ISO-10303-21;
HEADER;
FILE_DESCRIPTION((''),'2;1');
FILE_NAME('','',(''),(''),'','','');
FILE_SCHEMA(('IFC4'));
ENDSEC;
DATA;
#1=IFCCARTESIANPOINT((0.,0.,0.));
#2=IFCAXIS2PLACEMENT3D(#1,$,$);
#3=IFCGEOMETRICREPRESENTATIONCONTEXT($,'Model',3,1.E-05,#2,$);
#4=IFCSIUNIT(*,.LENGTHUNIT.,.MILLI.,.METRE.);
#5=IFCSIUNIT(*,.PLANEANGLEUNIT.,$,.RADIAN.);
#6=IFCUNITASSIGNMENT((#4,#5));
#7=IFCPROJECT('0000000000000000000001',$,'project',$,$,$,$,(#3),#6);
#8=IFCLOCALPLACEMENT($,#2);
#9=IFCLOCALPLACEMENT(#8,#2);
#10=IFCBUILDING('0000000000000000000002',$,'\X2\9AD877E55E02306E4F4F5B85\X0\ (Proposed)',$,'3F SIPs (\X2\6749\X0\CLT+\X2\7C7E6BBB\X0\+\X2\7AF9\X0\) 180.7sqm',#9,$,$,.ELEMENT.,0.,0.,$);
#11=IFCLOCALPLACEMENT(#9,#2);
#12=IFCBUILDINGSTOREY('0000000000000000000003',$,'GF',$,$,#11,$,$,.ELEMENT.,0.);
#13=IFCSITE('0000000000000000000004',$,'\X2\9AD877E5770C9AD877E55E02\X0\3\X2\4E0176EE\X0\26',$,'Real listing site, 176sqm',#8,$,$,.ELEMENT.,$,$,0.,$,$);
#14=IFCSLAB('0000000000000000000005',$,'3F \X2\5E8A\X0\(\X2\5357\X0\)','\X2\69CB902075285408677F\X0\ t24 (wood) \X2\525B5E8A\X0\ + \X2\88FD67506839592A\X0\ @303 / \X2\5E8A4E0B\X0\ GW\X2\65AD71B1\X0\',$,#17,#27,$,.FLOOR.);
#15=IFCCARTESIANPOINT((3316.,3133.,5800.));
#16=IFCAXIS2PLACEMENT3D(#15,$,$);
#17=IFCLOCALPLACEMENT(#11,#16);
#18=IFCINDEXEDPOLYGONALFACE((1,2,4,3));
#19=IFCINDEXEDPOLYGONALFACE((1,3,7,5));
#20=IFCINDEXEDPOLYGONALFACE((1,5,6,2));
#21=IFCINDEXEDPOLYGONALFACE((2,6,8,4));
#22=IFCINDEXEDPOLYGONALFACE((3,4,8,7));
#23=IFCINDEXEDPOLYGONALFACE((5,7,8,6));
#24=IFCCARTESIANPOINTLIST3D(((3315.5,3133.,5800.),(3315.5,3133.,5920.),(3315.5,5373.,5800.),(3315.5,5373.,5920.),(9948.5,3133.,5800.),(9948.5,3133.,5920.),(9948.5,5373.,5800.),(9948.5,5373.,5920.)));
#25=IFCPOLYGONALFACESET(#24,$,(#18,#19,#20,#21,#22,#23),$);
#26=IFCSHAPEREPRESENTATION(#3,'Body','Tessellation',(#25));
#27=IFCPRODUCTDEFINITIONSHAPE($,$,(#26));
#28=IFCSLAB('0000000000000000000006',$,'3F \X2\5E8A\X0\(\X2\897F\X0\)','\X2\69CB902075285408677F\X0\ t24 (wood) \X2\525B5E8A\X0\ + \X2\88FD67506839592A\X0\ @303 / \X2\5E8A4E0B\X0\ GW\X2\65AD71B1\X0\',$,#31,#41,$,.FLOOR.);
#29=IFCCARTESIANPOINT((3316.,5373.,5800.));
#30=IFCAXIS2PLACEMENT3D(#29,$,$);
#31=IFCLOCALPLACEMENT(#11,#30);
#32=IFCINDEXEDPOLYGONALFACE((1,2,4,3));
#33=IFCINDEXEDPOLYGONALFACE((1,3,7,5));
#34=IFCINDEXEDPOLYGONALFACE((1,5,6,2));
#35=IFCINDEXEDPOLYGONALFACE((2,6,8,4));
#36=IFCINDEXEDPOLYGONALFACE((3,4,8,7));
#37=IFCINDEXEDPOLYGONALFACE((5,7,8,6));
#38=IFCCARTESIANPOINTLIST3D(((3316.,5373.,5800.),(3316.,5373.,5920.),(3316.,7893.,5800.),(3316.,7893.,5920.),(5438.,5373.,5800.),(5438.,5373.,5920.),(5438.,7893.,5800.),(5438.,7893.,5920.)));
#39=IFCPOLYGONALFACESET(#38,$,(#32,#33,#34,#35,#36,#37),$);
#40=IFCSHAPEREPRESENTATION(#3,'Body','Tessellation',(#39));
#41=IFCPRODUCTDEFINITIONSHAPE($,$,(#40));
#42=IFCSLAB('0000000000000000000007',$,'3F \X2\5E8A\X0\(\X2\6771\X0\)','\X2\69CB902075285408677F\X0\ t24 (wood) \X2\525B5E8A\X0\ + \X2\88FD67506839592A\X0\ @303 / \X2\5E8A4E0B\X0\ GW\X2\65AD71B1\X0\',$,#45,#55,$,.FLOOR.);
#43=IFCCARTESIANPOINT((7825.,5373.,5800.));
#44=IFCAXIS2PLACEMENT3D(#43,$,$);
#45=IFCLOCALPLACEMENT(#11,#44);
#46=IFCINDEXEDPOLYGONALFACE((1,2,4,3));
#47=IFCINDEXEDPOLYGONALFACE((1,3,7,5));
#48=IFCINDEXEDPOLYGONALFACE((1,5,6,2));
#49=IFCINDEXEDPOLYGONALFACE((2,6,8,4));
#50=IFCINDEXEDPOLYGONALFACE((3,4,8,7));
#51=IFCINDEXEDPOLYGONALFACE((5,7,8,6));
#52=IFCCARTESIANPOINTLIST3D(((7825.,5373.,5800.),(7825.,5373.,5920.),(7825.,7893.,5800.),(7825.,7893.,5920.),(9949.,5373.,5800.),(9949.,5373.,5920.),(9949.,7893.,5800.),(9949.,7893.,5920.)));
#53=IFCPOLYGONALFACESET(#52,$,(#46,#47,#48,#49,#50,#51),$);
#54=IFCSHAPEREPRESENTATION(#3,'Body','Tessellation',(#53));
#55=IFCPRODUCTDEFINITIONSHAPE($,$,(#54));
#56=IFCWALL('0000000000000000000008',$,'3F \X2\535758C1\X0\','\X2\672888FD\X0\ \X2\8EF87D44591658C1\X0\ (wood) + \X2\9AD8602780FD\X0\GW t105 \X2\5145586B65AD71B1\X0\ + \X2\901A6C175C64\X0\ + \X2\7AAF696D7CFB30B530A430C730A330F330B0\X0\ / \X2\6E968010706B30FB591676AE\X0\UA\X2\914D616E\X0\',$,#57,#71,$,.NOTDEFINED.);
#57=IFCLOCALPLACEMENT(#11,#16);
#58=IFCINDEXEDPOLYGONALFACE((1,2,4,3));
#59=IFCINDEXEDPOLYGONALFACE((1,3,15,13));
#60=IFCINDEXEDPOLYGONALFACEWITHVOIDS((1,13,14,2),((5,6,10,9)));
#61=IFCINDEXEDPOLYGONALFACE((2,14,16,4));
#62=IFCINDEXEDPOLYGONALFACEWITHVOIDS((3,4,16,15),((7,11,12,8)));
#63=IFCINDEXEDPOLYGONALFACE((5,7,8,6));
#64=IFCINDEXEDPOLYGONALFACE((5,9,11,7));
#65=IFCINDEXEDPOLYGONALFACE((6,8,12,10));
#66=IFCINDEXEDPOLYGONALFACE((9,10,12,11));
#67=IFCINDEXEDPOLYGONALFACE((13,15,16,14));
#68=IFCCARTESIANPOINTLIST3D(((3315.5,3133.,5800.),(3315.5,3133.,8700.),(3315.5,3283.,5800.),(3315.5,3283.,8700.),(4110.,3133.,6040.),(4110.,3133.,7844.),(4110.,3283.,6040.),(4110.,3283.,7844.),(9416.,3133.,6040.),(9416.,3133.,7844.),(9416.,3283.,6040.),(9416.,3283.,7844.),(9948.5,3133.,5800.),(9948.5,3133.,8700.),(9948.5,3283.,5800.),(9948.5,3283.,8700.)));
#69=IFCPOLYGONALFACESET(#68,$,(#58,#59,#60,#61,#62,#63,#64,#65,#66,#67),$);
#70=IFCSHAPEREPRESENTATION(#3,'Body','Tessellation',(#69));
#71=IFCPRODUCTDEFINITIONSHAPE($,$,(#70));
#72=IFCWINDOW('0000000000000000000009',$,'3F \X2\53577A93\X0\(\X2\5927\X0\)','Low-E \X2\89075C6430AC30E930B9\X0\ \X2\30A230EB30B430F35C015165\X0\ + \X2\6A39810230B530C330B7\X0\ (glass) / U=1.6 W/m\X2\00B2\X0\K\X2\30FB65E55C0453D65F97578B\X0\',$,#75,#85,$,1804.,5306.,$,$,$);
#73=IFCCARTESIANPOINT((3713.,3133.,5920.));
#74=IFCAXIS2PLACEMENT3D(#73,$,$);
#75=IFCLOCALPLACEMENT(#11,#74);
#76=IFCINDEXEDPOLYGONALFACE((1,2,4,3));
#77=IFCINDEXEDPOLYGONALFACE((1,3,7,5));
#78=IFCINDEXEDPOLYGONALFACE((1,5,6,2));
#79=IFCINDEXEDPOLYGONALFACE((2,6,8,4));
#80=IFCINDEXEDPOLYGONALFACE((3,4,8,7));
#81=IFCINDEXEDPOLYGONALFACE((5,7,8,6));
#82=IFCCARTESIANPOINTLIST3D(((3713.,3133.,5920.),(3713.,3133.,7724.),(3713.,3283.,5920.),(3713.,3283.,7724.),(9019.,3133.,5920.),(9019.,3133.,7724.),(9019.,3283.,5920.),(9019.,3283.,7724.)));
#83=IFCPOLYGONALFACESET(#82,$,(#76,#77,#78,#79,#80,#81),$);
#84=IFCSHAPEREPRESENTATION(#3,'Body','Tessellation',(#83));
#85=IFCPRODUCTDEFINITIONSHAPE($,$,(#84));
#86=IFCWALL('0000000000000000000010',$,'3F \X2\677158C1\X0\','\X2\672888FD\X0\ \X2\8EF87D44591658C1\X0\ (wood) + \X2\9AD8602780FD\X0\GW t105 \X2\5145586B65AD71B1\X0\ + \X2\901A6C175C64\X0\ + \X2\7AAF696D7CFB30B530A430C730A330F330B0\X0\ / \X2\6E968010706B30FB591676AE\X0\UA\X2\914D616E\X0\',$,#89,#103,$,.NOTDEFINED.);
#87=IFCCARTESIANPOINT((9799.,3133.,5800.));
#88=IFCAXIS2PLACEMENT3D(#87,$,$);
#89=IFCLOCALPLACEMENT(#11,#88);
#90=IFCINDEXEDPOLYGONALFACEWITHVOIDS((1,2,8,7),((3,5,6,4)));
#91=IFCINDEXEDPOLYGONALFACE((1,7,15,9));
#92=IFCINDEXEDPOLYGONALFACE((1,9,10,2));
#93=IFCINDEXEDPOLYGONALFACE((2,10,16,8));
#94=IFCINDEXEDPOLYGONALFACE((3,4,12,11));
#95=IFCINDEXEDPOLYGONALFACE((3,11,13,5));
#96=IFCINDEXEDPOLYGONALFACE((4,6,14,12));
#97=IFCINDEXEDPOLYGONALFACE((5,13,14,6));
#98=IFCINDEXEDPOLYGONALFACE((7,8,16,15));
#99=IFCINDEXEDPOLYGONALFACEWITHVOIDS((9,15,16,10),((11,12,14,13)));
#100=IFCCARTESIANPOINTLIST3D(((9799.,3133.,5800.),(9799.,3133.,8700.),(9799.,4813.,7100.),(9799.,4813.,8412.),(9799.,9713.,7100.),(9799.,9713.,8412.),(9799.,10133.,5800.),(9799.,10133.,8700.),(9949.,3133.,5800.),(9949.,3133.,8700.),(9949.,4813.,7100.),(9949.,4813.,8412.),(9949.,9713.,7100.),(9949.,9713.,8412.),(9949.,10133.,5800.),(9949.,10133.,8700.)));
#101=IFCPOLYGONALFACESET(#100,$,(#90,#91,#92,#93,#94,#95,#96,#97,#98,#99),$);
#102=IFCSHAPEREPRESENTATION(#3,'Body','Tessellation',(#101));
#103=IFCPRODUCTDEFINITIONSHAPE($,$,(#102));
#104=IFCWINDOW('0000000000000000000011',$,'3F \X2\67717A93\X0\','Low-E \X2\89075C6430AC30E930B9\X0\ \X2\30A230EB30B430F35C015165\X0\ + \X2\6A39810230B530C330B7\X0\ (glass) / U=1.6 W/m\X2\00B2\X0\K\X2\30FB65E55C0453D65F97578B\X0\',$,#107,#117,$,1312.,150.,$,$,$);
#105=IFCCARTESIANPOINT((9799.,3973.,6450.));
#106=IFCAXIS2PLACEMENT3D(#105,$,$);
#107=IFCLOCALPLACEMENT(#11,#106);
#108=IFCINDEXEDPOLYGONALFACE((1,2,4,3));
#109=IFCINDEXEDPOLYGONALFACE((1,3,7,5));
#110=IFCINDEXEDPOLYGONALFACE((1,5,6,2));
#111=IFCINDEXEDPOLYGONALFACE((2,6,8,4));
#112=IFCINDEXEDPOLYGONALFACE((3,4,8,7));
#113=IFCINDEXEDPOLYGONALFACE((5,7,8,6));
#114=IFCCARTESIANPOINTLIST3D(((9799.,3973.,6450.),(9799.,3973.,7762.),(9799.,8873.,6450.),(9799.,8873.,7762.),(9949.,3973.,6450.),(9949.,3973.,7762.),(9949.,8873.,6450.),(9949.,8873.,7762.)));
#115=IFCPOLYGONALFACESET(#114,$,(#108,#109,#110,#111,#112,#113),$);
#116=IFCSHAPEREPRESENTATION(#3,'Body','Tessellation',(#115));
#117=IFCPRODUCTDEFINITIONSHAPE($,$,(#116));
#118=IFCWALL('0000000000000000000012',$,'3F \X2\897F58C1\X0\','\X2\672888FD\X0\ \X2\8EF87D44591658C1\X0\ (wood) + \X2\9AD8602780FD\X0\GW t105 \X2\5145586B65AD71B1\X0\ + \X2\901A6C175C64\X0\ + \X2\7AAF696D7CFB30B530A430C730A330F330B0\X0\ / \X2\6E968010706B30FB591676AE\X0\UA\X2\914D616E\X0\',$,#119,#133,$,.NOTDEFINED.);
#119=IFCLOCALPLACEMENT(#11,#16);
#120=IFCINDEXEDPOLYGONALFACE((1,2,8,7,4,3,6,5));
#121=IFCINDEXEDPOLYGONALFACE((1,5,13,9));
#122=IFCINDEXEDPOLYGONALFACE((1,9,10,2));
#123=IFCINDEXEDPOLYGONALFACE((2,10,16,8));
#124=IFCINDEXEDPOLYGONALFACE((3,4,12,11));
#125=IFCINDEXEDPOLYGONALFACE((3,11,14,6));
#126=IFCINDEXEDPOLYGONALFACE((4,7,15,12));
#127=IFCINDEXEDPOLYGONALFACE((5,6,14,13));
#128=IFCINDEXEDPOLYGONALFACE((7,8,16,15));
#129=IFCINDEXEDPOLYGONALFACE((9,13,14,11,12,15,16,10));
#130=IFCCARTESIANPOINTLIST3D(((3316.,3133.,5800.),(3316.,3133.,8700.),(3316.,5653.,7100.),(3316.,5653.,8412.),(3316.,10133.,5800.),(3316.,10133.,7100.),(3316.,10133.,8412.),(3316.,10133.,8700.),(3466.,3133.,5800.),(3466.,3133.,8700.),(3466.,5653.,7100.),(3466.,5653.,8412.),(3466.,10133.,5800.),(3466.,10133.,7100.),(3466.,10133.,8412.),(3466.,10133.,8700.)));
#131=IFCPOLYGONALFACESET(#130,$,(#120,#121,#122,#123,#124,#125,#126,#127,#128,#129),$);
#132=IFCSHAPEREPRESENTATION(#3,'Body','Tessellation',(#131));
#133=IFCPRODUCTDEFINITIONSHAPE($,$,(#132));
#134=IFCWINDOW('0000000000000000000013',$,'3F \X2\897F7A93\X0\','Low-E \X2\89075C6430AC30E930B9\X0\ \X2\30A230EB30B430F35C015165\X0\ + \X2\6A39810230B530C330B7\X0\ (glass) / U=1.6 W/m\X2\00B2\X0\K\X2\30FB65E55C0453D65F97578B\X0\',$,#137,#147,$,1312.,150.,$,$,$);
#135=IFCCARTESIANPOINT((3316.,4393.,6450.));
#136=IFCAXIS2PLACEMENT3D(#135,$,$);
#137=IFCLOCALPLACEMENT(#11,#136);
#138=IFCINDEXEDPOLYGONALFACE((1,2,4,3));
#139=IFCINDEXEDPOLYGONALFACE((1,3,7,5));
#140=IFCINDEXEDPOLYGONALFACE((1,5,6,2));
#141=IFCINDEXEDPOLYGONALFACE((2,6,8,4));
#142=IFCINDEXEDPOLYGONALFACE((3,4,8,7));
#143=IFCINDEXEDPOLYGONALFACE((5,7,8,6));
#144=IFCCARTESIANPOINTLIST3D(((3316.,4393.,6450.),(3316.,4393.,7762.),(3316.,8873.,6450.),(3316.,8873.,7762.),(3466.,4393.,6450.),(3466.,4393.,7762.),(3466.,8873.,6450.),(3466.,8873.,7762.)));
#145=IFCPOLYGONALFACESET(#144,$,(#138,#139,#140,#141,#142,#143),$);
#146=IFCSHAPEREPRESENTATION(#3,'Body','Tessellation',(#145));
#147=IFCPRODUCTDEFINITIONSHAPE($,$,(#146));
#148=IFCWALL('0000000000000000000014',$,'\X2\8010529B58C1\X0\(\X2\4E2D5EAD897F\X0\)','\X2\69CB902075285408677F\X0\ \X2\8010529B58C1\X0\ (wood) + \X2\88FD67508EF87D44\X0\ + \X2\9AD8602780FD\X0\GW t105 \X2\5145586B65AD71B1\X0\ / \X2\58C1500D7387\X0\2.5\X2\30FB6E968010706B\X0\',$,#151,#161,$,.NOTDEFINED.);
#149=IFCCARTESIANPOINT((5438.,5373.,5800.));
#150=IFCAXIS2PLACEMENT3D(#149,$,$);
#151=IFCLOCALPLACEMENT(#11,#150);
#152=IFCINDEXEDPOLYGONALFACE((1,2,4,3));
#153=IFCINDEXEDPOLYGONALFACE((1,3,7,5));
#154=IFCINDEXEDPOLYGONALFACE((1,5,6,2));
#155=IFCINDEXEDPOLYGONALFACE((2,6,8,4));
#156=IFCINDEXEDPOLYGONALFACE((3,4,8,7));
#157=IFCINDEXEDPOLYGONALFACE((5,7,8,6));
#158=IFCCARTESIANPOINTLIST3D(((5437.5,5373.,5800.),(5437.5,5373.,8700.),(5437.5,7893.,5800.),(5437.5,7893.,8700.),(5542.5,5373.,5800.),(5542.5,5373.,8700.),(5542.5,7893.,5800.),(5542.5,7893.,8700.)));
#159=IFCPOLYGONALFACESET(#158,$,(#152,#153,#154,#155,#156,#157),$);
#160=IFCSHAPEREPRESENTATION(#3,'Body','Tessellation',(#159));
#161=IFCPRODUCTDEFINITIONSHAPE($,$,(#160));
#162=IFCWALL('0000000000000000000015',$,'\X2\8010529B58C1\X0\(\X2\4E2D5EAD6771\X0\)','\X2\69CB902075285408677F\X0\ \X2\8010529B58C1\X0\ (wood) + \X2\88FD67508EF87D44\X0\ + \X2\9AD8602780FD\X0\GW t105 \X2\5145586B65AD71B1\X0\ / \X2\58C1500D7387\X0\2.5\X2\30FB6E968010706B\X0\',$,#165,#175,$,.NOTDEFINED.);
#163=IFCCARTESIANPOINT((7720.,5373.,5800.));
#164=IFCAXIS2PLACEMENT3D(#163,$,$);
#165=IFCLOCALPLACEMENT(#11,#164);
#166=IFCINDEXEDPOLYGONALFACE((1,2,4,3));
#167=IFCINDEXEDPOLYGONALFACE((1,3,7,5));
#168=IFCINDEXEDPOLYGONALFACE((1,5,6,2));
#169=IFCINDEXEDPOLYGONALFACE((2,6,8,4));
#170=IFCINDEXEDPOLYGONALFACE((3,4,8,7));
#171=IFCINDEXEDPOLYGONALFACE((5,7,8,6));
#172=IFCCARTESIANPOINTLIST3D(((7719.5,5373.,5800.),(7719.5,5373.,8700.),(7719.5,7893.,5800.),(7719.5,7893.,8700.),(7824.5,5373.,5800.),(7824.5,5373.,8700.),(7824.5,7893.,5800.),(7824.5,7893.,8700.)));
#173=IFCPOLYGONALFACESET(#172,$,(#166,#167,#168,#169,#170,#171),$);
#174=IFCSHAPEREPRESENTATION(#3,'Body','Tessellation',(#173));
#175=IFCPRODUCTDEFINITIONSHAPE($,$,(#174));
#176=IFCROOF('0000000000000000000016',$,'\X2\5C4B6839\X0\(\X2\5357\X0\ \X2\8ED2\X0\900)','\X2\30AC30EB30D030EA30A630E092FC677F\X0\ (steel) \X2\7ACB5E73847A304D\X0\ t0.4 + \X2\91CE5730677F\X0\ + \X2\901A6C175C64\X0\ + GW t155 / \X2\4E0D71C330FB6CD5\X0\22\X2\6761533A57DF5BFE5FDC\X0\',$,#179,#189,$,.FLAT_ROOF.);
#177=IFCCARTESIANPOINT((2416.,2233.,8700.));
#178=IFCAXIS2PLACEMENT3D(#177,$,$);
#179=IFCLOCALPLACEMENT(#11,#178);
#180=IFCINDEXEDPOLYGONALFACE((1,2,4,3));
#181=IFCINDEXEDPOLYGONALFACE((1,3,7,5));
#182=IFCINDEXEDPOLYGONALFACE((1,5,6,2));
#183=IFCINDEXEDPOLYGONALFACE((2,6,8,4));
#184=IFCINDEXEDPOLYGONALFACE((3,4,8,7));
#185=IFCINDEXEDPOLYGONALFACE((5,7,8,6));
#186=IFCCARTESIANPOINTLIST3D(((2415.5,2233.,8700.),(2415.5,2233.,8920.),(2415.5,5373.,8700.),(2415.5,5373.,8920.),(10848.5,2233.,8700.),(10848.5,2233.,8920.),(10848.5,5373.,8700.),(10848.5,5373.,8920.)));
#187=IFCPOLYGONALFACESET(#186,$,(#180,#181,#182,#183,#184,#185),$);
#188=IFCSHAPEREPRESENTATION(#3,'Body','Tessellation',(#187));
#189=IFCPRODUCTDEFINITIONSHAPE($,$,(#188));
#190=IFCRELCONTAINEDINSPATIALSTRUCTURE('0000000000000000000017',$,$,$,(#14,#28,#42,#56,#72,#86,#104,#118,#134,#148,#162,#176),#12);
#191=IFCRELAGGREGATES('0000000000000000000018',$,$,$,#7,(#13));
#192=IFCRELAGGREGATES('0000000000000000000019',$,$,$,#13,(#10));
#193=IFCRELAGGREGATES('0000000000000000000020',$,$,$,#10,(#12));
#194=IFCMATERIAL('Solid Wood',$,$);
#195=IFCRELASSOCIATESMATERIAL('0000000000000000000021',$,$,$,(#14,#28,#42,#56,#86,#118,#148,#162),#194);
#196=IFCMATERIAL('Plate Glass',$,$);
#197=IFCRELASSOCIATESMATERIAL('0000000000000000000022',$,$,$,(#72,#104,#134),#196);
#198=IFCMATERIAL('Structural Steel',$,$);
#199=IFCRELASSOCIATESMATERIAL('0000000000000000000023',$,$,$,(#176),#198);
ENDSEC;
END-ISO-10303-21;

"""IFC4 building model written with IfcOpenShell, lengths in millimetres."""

from ifc_helpers import new_model, si_unit, frame, frame_2d, origin, place, context, project, spatial, rectangle, extrude, material, element, fill, save


model = new_model("IFC4")

# Units and contexts
model_context = context("Model", 3, precision=1e-05, world=origin())
ifc_project = project(units=[si_unit("LENGTHUNIT", "METRE", prefix="MILLI"), si_unit("PLANEANGLEUNIT", "RADIAN")], contexts=[model_context])

# Site, building, storey
site_placement = place(None, origin())
site = spatial("IfcSite", under=ifc_project, at=site_placement, Name="高知県高知市3丁目26", ObjectType="Real listing site, 176sqm", CompositionType="ELEMENT", RefElevation=0.0)
building_placement = place(site_placement, origin())
building = spatial("IfcBuilding", under=site, at=building_placement, Name="高知市の住宅 (Proposed)", ObjectType="3F SIPs (杉CLT+籾殻+竹) 180.7sqm", CompositionType="ELEMENT", ElevationOfRefHeight=0.0, ElevationOfTerrain=0.0)
storey_placement = place(building_placement, origin())
storey = spatial("IfcBuildingStorey", under=building, at=storey_placement, Name="GF", CompositionType="ELEMENT", Elevation=0.0)

# Slabs
ifc_material_1 = material(Name="Solid Wood")
slab_1_placement = place(storey_placement, frame((3316.0, 3133.0, 5800.0)))
element("IfcSlab", 1, at=slab_1_placement, inside=storey, material=ifc_material_1, Name="3F 床(南)", Description="構造用合板 t24 (wood) 剛床 + 製材根太 @303 / 床下 GW断熱", PredefinedType="FLOOR", context=model_context, shape_type="SweptSolid", body=[
    extrude(rectangle(XDim=6633.0, YDim=2240.0, at=frame_2d((3316.0, 1120.0))), frame((3316.0, 3133.0, 5800.0)), (0.0, 0.0, 1.0), 120.0),
])
slab_2_placement = place(storey_placement, frame((3316.0, 5373.0, 5800.0)))
element("IfcSlab", 2, at=slab_2_placement, inside=storey, material=ifc_material_1, Name="3F 床(西)", Description="構造用合板 t24 (wood) 剛床 + 製材根太 @303 / 床下 GW断熱", PredefinedType="FLOOR", context=model_context, shape_type="SweptSolid", body=[
    extrude(rectangle(XDim=2122.0, YDim=2520.0, at=frame_2d((1061.0, 1260.0))), frame((3316.0, 5373.0, 5800.0)), (0.0, 0.0, 1.0), 120.0),
])
slab_3_placement = place(storey_placement, frame((7825.0, 5373.0, 5800.0)))
element("IfcSlab", 3, at=slab_3_placement, inside=storey, material=ifc_material_1, Name="3F 床(東)", Description="構造用合板 t24 (wood) 剛床 + 製材根太 @303 / 床下 GW断熱", PredefinedType="FLOOR", context=model_context, shape_type="SweptSolid", body=[
    extrude(rectangle(XDim=2124.0, YDim=2520.0, at=frame_2d((1062.0, 1260.0))), frame((7825.0, 5373.0, 5800.0)), (0.0, 0.0, 1.0), 120.0),
])

# Walls, openings, windows
wall_1_placement = place(storey_placement, frame((3316.0, 3133.0, 5800.0)))
wall_1 = element("IfcWall", 4, at=wall_1_placement, inside=storey, material=ifc_material_1, Name="3F 南壁", Description="木製 軸組外壁 (wood) + 高性能GW t105 充填断熱 + 通気層 + 窯業系サイディング / 準耐火・外皮UA配慮", PredefinedType="NOTDEFINED", context=model_context, shape_type="SweptSolid", body=[
    extrude(rectangle(XDim=6633.0, YDim=150.0, at=frame_2d((3316.0, 75.0))), frame((3316.0, 3133.0, 5800.0)), (0.0, 0.0, 1.0), 2900.0),
])
opening_1_placement = place(storey_placement, frame((3713.0, 3133.0, 5920.0)))
opening_1 = element("IfcOpeningElement", 5, at=opening_1_placement, cuts=wall_1, PredefinedType="NOTDEFINED", context=model_context, shape_type="SweptSolid", body=[
    extrude(rectangle(XDim=5306.0, YDim=150.0, at=frame_2d((2653.0, 75.0))), frame((3713.0, 3133.0, 5920.0)), (0.0, 0.0, 1.0), 1804.0),
])
ifc_material_2 = material(Name="Plate Glass")
window_1_placement = place(storey_placement, frame((3713.0, 3133.0, 5920.0)))
window_1 = element("IfcWindow", 6, at=window_1_placement, inside=storey, material=ifc_material_2, Name="3F 南窓(大)", Description="Low-E 複層ガラス アルゴン封入 + 樹脂サッシ (glass) / U=1.6 W/m²K・日射取得型", OverallHeight=1804.0, OverallWidth=5306.0, context=model_context, shape_type="SweptSolid", body=[
    extrude(rectangle(XDim=5306.0, YDim=150.0, at=frame_2d((2653.0, 75.0))), frame((3713.0, 3133.0, 5920.0)), (0.0, 0.0, 1.0), 1804.0),
])
fill(opening_1, window_1)
wall_2_placement = place(storey_placement, frame((9799.0, 3133.0, 5800.0)))
wall_2 = element("IfcWall", 7, at=wall_2_placement, inside=storey, material=ifc_material_1, Name="3F 東壁", Description="木製 軸組外壁 (wood) + 高性能GW t105 充填断熱 + 通気層 + 窯業系サイディング / 準耐火・外皮UA配慮", PredefinedType="NOTDEFINED", context=model_context, shape_type="SweptSolid", body=[
    extrude(rectangle(XDim=150.0, YDim=7000.0, at=frame_2d((75.0, 3500.0))), frame((9799.0, 3133.0, 5800.0)), (0.0, 0.0, 1.0), 2900.0),
])
opening_2_placement = place(storey_placement, frame((9799.0, 3973.0, 6450.0)))
opening_2 = element("IfcOpeningElement", 8, at=opening_2_placement, cuts=wall_2, PredefinedType="NOTDEFINED", context=model_context, shape_type="SweptSolid", body=[
    extrude(rectangle(XDim=150.0, YDim=4900.0, at=frame_2d((75.0, 2450.0))), frame((9799.0, 3973.0, 6450.0)), (0.0, 0.0, 1.0), 1312.0),
])
window_2_placement = place(storey_placement, frame((9799.0, 3973.0, 6450.0)))
window_2 = element("IfcWindow", 9, at=window_2_placement, inside=storey, material=ifc_material_2, Name="3F 東窓", Description="Low-E 複層ガラス アルゴン封入 + 樹脂サッシ (glass) / U=1.6 W/m²K・日射取得型", OverallHeight=1312.0, OverallWidth=150.0, context=model_context, shape_type="SweptSolid", body=[
    extrude(rectangle(XDim=150.0, YDim=4900.0, at=frame_2d((75.0, 2450.0))), frame((9799.0, 3973.0, 6450.0)), (0.0, 0.0, 1.0), 1312.0),
])
fill(opening_2, window_2)
wall_3_placement = place(storey_placement, frame((3316.0, 3133.0, 5800.0)))
wall_3 = element("IfcWall", 10, at=wall_3_placement, inside=storey, material=ifc_material_1, Name="3F 西壁", Description="木製 軸組外壁 (wood) + 高性能GW t105 充填断熱 + 通気層 + 窯業系サイディング / 準耐火・外皮UA配慮", PredefinedType="NOTDEFINED", context=model_context, shape_type="SweptSolid", body=[
    extrude(rectangle(XDim=150.0, YDim=7000.0, at=frame_2d((75.0, 3500.0))), frame((3316.0, 3133.0, 5800.0)), (0.0, 0.0, 1.0), 2900.0),
])
opening_3_placement = place(storey_placement, frame((3316.0, 4393.0, 6450.0)))
opening_3 = element("IfcOpeningElement", 11, at=opening_3_placement, cuts=wall_3, PredefinedType="NOTDEFINED", context=model_context, shape_type="SweptSolid", body=[
    extrude(rectangle(XDim=150.0, YDim=4480.0, at=frame_2d((75.0, 2240.0))), frame((3316.0, 4393.0, 6450.0)), (0.0, 0.0, 1.0), 1312.0),
])
window_3_placement = place(storey_placement, frame((3316.0, 4393.0, 6450.0)))
window_3 = element("IfcWindow", 12, at=window_3_placement, inside=storey, material=ifc_material_2, Name="3F 西窓", Description="Low-E 複層ガラス アルゴン封入 + 樹脂サッシ (glass) / U=1.6 W/m²K・日射取得型", OverallHeight=1312.0, OverallWidth=150.0, context=model_context, shape_type="SweptSolid", body=[
    extrude(rectangle(XDim=150.0, YDim=4480.0, at=frame_2d((75.0, 2240.0))), frame((3316.0, 4393.0, 6450.0)), (0.0, 0.0, 1.0), 1312.0),
])
fill(opening_3, window_3)

# Walls
wall_4_placement = place(storey_placement, frame((5438.0, 5373.0, 5800.0)))
element("IfcWall", 13, at=wall_4_placement, inside=storey, material=ifc_material_1, Name="耐力壁(中庭西)", Description="構造用合板 耐力壁 (wood) + 製材軸組 + 高性能GW t105 充填断熱 / 壁倍率2.5・準耐火", PredefinedType="NOTDEFINED", context=model_context, shape_type="SweptSolid", body=[
    extrude(rectangle(XDim=105.0, YDim=2520.0, at=frame_2d((52.0, 1260.0))), frame((5438.0, 5373.0, 5800.0)), (0.0, 0.0, 1.0), 2900.0),
])
wall_5_placement = place(storey_placement, frame((7720.0, 5373.0, 5800.0)))
element("IfcWall", 14, at=wall_5_placement, inside=storey, material=ifc_material_1, Name="耐力壁(中庭東)", Description="構造用合板 耐力壁 (wood) + 製材軸組 + 高性能GW t105 充填断熱 / 壁倍率2.5・準耐火", PredefinedType="NOTDEFINED", context=model_context, shape_type="SweptSolid", body=[
    extrude(rectangle(XDim=105.0, YDim=2520.0, at=frame_2d((52.0, 1260.0))), frame((7720.0, 5373.0, 5800.0)), (0.0, 0.0, 1.0), 2900.0),
])

# Roof
ifc_material_3 = material(Name="Structural Steel")
roof_1_placement = place(storey_placement, frame((2416.0, 2233.0, 8700.0)))
element("IfcRoof", 15, at=roof_1_placement, inside=storey, material=ifc_material_3, Name="屋根(南 軒900)", Description="ガルバリウム鋼板 (steel) 立平葺き t0.4 + 野地板 + 通気層 + GW t155 / 不燃・法22条区域対応", PredefinedType="FLAT_ROOF", context=model_context, shape_type="SweptSolid", body=[
    extrude(rectangle(XDim=8433.0, YDim=3140.0, at=frame_2d((4216.0, 1570.0))), frame((2416.0, 2233.0, 8700.0)), (0.0, 0.0, 1.0), 220.0),
])

save(model, "model.ifc")
